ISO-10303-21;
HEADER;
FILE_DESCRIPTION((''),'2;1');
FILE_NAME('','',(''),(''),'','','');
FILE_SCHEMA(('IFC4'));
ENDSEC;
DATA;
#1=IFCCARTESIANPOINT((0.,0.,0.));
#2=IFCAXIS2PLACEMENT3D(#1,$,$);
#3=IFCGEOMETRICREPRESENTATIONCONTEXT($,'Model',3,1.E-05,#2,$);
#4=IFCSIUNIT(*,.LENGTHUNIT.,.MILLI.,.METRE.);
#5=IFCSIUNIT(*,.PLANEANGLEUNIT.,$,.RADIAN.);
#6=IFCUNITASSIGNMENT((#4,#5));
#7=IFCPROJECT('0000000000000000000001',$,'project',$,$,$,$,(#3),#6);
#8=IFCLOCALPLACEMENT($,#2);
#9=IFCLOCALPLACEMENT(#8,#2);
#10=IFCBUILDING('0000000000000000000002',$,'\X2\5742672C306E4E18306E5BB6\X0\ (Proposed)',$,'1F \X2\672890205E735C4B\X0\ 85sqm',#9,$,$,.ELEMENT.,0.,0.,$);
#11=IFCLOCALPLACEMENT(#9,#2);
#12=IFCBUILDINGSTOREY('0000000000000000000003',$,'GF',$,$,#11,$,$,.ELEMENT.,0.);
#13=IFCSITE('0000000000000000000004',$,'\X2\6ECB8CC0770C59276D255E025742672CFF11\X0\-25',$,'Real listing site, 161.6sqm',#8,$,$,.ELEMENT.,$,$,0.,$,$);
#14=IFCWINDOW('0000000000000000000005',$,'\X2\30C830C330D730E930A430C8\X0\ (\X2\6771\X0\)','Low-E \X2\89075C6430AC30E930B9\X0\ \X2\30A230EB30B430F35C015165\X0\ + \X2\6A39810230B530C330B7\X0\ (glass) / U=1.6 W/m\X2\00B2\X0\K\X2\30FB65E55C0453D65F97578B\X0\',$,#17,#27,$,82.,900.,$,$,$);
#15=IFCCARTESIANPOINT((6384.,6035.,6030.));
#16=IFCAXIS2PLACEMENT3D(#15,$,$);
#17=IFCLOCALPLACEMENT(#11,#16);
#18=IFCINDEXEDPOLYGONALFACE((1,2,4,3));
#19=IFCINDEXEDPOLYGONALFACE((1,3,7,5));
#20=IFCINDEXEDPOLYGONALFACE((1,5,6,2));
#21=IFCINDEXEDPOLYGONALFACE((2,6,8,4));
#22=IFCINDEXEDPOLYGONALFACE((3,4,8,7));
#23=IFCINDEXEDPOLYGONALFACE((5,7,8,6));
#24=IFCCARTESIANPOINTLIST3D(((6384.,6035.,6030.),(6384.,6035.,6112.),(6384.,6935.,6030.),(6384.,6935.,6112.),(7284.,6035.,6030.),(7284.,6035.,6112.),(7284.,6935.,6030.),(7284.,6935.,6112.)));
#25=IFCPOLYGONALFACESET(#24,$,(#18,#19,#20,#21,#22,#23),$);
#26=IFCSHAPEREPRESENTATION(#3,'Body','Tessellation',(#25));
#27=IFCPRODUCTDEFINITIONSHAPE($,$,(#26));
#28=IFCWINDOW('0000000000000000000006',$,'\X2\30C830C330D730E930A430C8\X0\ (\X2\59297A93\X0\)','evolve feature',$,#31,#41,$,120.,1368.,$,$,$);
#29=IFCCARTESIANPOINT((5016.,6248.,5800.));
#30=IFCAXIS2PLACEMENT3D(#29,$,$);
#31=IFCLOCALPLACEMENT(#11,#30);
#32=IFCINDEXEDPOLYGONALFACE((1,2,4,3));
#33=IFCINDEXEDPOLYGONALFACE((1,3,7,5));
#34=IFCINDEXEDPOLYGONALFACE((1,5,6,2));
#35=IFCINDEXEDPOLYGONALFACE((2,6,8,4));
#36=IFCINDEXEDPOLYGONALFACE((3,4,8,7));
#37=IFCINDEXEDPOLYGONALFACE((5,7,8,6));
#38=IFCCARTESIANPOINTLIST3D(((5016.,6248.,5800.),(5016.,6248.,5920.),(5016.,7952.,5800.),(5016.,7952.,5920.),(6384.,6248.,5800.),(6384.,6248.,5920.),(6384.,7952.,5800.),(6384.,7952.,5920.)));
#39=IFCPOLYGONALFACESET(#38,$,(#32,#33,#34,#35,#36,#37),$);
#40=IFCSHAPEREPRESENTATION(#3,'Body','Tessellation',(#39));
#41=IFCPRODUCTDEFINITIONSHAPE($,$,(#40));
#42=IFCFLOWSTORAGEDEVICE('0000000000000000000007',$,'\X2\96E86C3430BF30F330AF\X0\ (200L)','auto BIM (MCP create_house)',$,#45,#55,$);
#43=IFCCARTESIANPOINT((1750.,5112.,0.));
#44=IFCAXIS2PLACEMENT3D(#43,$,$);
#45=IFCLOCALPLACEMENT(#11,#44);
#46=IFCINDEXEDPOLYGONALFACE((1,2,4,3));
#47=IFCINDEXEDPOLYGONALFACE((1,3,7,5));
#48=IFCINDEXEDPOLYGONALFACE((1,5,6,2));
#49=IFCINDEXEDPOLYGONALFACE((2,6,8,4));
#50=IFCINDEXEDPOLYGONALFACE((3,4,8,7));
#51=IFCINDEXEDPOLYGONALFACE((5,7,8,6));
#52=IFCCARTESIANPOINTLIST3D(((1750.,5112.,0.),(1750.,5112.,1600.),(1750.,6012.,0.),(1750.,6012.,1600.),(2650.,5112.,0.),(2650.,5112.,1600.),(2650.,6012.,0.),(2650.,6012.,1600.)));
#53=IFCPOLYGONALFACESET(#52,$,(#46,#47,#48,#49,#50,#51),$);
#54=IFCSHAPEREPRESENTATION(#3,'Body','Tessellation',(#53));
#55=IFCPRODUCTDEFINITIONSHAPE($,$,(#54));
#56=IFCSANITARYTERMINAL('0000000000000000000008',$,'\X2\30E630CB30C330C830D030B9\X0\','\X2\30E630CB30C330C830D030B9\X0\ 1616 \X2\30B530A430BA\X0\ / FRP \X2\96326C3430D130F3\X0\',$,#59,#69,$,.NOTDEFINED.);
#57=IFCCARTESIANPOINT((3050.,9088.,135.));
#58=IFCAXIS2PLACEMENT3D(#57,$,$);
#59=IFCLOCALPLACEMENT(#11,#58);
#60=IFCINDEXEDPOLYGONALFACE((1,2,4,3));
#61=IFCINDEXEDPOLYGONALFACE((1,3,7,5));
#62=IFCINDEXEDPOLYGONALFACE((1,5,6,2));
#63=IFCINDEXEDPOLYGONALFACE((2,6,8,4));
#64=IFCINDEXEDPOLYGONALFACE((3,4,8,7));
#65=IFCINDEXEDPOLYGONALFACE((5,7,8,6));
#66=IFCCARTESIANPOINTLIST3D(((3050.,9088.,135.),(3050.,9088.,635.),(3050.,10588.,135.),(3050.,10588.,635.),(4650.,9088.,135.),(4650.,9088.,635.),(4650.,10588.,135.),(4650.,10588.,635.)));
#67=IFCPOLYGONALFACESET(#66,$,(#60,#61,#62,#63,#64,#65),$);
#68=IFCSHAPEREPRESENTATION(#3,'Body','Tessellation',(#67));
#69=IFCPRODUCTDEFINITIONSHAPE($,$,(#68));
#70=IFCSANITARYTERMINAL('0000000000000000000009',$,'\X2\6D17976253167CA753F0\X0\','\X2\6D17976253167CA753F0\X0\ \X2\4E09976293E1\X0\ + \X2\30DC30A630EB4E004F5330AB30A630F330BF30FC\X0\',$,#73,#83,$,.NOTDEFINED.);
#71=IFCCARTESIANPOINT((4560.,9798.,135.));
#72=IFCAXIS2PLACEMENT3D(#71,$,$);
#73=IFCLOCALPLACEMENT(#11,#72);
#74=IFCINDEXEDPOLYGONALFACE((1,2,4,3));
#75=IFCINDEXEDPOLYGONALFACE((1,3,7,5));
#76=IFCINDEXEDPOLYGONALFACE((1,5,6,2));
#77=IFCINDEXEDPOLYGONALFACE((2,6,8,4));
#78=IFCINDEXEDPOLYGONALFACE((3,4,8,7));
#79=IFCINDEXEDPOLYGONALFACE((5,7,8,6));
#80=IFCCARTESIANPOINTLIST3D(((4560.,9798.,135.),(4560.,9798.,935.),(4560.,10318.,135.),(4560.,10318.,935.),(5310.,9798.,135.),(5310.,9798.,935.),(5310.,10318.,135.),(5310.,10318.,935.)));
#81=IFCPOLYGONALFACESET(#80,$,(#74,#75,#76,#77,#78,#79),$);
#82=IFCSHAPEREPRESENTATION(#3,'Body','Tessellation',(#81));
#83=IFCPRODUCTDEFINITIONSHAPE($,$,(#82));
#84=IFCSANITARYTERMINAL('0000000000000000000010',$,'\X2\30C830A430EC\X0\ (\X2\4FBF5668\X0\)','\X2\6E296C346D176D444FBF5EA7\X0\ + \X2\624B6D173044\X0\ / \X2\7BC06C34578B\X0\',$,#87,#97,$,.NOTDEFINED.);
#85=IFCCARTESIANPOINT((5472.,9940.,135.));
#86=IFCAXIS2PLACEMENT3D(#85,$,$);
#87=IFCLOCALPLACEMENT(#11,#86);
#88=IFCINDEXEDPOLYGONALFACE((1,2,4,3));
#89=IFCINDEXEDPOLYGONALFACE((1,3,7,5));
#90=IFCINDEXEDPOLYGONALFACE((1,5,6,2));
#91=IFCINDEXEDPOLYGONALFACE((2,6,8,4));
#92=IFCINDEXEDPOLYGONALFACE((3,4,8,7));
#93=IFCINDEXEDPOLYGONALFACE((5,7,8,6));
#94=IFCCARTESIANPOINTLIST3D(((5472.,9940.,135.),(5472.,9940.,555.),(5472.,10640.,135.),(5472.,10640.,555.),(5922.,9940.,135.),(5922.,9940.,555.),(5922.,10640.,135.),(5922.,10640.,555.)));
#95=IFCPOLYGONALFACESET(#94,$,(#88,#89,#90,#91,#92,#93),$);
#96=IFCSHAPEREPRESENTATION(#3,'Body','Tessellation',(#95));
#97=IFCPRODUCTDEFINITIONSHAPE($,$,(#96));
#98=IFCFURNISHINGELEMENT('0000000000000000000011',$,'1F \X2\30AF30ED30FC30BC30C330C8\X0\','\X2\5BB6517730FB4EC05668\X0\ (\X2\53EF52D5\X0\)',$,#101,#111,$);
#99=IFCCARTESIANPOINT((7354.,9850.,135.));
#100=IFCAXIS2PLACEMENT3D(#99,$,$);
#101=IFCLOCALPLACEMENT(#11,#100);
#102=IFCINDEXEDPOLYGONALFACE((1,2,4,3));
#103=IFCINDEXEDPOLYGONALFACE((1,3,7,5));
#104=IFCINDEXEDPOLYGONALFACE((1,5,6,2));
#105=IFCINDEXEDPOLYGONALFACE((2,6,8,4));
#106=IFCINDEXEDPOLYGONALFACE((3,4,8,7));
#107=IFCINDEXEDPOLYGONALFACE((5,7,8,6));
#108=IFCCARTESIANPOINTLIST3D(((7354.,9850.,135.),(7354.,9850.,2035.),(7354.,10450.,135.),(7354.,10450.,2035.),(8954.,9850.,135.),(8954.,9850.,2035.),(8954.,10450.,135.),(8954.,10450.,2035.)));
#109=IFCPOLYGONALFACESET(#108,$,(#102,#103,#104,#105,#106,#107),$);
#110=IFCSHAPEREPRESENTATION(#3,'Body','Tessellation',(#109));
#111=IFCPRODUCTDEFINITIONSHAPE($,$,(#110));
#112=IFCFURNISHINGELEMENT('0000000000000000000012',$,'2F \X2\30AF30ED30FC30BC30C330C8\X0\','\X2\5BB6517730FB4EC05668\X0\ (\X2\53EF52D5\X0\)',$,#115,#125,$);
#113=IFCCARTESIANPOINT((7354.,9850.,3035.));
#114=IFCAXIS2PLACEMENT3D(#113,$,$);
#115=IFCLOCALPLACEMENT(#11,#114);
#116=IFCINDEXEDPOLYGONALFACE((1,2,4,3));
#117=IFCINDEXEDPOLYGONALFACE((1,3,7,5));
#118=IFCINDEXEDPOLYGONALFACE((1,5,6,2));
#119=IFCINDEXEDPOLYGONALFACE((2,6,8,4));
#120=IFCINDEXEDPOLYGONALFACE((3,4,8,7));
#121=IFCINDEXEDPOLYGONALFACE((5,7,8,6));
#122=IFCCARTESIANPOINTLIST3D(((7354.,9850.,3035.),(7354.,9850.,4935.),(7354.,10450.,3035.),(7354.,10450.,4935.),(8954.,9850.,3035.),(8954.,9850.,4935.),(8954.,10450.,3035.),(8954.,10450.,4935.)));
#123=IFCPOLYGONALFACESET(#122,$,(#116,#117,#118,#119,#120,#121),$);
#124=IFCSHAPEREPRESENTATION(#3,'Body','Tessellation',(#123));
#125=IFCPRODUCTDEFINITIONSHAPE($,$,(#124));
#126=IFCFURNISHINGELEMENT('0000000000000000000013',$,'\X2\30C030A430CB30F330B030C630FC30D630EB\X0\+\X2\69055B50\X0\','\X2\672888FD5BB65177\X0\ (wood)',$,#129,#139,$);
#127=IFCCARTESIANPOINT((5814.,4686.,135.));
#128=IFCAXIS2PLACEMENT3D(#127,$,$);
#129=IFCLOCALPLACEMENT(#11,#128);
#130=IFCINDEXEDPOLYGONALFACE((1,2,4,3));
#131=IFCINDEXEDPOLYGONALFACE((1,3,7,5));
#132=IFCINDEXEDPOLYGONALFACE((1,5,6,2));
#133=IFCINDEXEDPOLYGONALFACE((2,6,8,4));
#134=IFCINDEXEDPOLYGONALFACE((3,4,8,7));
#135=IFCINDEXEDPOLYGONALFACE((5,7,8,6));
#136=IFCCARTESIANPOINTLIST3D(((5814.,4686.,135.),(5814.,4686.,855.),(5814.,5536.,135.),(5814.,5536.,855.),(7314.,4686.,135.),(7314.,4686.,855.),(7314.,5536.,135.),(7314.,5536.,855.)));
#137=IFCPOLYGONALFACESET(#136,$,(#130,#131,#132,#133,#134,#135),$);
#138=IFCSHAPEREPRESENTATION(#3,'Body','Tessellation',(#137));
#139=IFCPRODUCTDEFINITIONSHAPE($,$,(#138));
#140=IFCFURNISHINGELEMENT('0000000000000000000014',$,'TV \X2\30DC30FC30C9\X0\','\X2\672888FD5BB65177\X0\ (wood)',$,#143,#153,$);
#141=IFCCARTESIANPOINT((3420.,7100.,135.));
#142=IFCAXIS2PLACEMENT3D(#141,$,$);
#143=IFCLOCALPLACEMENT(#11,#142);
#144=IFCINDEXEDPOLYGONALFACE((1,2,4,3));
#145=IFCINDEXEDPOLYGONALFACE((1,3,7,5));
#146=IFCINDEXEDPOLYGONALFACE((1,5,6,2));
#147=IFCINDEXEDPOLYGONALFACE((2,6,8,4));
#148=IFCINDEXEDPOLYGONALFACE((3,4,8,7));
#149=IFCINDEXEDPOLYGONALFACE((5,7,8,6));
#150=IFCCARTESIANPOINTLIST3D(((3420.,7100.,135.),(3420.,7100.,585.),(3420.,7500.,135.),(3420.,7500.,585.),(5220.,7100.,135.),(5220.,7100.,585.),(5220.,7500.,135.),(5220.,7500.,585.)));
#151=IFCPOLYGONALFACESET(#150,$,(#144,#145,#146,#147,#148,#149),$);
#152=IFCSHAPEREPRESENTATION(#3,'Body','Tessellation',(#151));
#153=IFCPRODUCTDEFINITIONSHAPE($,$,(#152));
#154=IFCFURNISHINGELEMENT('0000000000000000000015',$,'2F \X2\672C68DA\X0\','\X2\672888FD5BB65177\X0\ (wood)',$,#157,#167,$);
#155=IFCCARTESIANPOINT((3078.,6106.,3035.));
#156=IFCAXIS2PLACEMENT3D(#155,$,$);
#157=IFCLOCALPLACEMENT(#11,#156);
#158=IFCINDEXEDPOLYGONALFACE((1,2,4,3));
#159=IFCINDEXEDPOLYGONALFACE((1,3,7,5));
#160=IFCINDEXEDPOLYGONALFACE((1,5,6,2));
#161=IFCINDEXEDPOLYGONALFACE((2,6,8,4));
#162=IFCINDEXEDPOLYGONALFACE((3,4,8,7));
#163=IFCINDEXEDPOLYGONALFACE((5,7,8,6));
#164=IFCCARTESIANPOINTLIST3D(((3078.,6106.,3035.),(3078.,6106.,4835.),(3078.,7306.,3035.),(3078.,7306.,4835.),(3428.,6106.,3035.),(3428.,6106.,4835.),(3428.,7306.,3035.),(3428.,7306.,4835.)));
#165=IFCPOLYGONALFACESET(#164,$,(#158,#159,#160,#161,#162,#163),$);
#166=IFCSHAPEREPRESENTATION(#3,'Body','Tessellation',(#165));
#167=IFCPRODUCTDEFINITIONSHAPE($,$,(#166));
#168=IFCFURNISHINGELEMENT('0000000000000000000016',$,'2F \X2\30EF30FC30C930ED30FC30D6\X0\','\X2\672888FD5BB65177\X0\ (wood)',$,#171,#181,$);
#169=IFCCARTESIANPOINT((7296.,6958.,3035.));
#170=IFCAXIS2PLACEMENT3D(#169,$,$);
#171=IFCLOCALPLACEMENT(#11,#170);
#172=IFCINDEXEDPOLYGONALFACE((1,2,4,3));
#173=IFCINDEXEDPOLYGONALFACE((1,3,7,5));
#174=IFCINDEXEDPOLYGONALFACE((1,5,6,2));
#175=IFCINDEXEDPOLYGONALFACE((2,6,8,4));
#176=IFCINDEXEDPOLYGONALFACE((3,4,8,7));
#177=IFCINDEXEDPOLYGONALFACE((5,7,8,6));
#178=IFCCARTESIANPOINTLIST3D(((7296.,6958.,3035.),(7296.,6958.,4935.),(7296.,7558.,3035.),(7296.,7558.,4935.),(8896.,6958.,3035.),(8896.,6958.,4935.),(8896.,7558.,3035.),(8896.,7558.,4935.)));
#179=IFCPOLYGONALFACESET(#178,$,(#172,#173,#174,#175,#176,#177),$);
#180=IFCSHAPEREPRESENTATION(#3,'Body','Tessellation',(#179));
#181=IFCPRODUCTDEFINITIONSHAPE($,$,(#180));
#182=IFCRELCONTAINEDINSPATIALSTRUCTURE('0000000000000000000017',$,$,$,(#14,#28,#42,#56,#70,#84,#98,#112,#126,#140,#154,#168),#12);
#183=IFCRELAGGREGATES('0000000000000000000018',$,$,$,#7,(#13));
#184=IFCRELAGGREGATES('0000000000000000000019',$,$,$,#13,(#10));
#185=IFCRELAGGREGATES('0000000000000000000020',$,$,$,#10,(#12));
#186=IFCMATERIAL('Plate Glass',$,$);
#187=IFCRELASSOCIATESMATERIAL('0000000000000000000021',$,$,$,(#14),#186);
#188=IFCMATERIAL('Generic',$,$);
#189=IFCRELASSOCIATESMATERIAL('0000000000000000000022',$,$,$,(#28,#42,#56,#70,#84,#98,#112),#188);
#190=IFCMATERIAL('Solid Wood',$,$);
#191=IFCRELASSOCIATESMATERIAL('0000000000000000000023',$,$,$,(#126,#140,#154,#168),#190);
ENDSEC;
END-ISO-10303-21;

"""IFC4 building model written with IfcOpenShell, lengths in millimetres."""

from ifc_helpers import new_model, si_unit, frame, frame_2d, origin, place, context, project, spatial, rectangle, extrude, material, element, save


model = new_model("IFC4")

# Units and contexts
model_context = context("Model", 3, precision=1e-05, world=origin())
ifc_project = project(units=[si_unit("LENGTHUNIT", "METRE", prefix="MILLI"), si_unit("PLANEANGLEUNIT", "RADIAN")], contexts=[model_context])

# Site, building, storey
site_placement = place(None, origin())
site = spatial("IfcSite", under=ifc_project, at=site_placement, Name="滋賀県大津市坂本１-25", ObjectType="Real listing site, 161.6sqm", CompositionType="ELEMENT", RefElevation=0.0)
building_placement = place(site_placement, origin())
building = spatial("IfcBuilding", under=site, at=building_placement, Name="坂本の丘の家 (Proposed)", ObjectType="1F 木造平屋 85sqm", CompositionType="ELEMENT", ElevationOfRefHeight=0.0, ElevationOfTerrain=0.0)
storey_placement = place(building_placement, origin())
storey = spatial("IfcBuildingStorey", under=building, at=storey_placement, Name="GF", CompositionType="ELEMENT", Elevation=0.0)

# Shared definitions
ifc_material_1 = material(Name="Solid Wood")
ifc_material_2 = material(Name="Plate Glass")

# Windows
window_1_placement = place(storey_placement, frame((6384.0, 6035.0, 6030.0)))
element("IfcWindow", 1, at=window_1_placement, inside=storey, material=ifc_material_2, Name="トップライト (東)", Description="Low-E 複層ガラス アルゴン封入 + 樹脂サッシ (glass) / U=1.6 W/m²K・日射取得型", OverallHeight=82.0, OverallWidth=900.0, context=model_context, shape_type="SweptSolid", body=[
    extrude(rectangle(XDim=900.0, YDim=900.0, at=frame_2d((450.0, 450.0))), frame((6384.0, 6035.0, 6030.0)), (0.0, 0.0, 1.0), 82.0),
])
ifc_material_3 = material(Name="Generic")
window_2_placement = place(storey_placement, frame((5016.0, 6248.0, 5800.0)))
element("IfcWindow", 2, at=window_2_placement, inside=storey, material=ifc_material_3, Name="トップライト (天窓)", Description="evolve feature", OverallHeight=120.0, OverallWidth=1368.0, context=model_context, shape_type="SweptSolid", body=[
    extrude(rectangle(XDim=1368.0, YDim=1704.0, at=frame_2d((684.0, 852.0))), frame((5016.0, 6248.0, 5800.0)), (0.0, 0.0, 1.0), 120.0),
])

# Flow storage device
flow_storage_device_placement = place(storey_placement, frame((1750.0, 5112.0, 0.0)))
element("IfcFlowStorageDevice", 3, at=flow_storage_device_placement, inside=storey, material=ifc_material_3, Name="雨水タンク (200L)", Description="auto BIM (MCP create_house)", context=model_context, shape_type="SweptSolid", body=[
    extrude(rectangle(XDim=900.0, YDim=900.0, at=frame_2d((450.0, 450.0))), frame((1750.0, 5112.0, 0.0)), (0.0, 0.0, 1.0), 1600.0),
])

# Sanitary terminals
sanitary_terminal_1_placement = place(storey_placement, frame((3050.0, 9088.0, 135.0)))
element("IfcSanitaryTerminal", 4, at=sanitary_terminal_1_placement, inside=storey, material=ifc_material_3, Name="ユニットバス", Description="ユニットバス 1616 サイズ / FRP 防水パン", PredefinedType="NOTDEFINED", context=model_context, shape_type="SweptSolid", body=[
    extrude(rectangle(XDim=1600.0, YDim=1500.0, at=frame_2d((800.0, 750.0))), frame((3050.0, 9088.0, 135.0)), (0.0, 0.0, 1.0), 500.0),
])
sanitary_terminal_2_placement = place(storey_placement, frame((4560.0, 9798.0, 135.0)))
element("IfcSanitaryTerminal", 5, at=sanitary_terminal_2_placement, inside=storey, material=ifc_material_3, Name="洗面化粧台", Description="洗面化粧台 三面鏡 + ボウル一体カウンター", PredefinedType="NOTDEFINED", context=model_context, shape_type="SweptSolid", body=[
    extrude(rectangle(XDim=750.0, YDim=520.0, at=frame_2d((375.0, 260.0))), frame((4560.0, 9798.0, 135.0)), (0.0, 0.0, 1.0), 800.0),
])
sanitary_terminal_3_placement = place(storey_placement, frame((5472.0, 9940.0, 135.0)))
element("IfcSanitaryTerminal", 6, at=sanitary_terminal_3_placement, inside=storey, material=ifc_material_3, Name="トイレ (便器)", Description="温水洗浄便座 + 手洗い / 節水型", PredefinedType="NOTDEFINED", context=model_context, shape_type="SweptSolid", body=[
    extrude(rectangle(XDim=450.0, YDim=700.0, at=frame_2d((225.0, 350.0))), frame((5472.0, 9940.0, 135.0)), (0.0, 0.0, 1.0), 420.0),
])

# Furnishing elements
furnishing_1_placement = place(storey_placement, frame((7354.0, 9850.0, 135.0)))
element("IfcFurnishingElement", 7, at=furnishing_1_placement, inside=storey, material=ifc_material_3, Name="1F クローゼット", Description="家具・什器 (可動)", context=model_context, shape_type="SweptSolid", body=[
    extrude(rectangle(XDim=1600.0, YDim=600.0, at=frame_2d((800.0, 300.0))), frame((7354.0, 9850.0, 135.0)), (0.0, 0.0, 1.0), 1900.0),
])
furnishing_2_placement = place(storey_placement, frame((7354.0, 9850.0, 3035.0)))
element("IfcFurnishingElement", 8, at=furnishing_2_placement, inside=storey, material=ifc_material_3, Name="2F クローゼット", Description="家具・什器 (可動)", context=model_context, shape_type="SweptSolid", body=[
    extrude(rectangle(XDim=1600.0, YDim=600.0, at=frame_2d((800.0, 300.0))), frame((7354.0, 9850.0, 3035.0)), (0.0, 0.0, 1.0), 1900.0),
])
furnishing_3_placement = place(storey_placement, frame((5814.0, 4686.0, 135.0)))
element("IfcFurnishingElement", 9, at=furnishing_3_placement, inside=storey, material=ifc_material_1, Name="ダイニングテーブル+椅子", Description="木製家具 (wood)", context=model_context, shape_type="SweptSolid", body=[
    extrude(rectangle(XDim=1500.0, YDim=850.0, at=frame_2d((750.0, 425.0))), frame((5814.0, 4686.0, 135.0)), (0.0, 0.0, 1.0), 720.0),
])
furnishing_4_placement = place(storey_placement, frame((3420.0, 7100.0, 135.0)))
element("IfcFurnishingElement", 10, at=furnishing_4_placement, inside=storey, material=ifc_material_1, Name="TV ボード", Description="木製家具 (wood)", context=model_context, shape_type="SweptSolid", body=[
    extrude(rectangle(XDim=1800.0, YDim=400.0, at=frame_2d((900.0, 200.0))), frame((3420.0, 7100.0, 135.0)), (0.0, 0.0, 1.0), 450.0),
])
furnishing_5_placement = place(storey_placement, frame((3078.0, 6106.0, 3035.0)))
element("IfcFurnishingElement", 11, at=furnishing_5_placement, inside=storey, material=ifc_material_1, Name="2F 本棚", Description="木製家具 (wood)", context=model_context, shape_type="SweptSolid", body=[
    extrude(rectangle(XDim=350.0, YDim=1200.0, at=frame_2d((175.0, 600.0))), frame((3078.0, 6106.0, 3035.0)), (0.0, 0.0, 1.0), 1800.0),
])
furnishing_6_placement = place(storey_placement, frame((7296.0, 6958.0, 3035.0)))
element("IfcFurnishingElement", 12, at=furnishing_6_placement, inside=storey, material=ifc_material_1, Name="2F ワードローブ", Description="木製家具 (wood)", context=model_context, shape_type="SweptSolid", body=[
    extrude(rectangle(XDim=1600.0, YDim=600.0, at=frame_2d((800.0, 300.0))), frame((7296.0, 6958.0, 3035.0)), (0.0, 0.0, 1.0), 1900.0),
])

save(model, "model.ifc")
